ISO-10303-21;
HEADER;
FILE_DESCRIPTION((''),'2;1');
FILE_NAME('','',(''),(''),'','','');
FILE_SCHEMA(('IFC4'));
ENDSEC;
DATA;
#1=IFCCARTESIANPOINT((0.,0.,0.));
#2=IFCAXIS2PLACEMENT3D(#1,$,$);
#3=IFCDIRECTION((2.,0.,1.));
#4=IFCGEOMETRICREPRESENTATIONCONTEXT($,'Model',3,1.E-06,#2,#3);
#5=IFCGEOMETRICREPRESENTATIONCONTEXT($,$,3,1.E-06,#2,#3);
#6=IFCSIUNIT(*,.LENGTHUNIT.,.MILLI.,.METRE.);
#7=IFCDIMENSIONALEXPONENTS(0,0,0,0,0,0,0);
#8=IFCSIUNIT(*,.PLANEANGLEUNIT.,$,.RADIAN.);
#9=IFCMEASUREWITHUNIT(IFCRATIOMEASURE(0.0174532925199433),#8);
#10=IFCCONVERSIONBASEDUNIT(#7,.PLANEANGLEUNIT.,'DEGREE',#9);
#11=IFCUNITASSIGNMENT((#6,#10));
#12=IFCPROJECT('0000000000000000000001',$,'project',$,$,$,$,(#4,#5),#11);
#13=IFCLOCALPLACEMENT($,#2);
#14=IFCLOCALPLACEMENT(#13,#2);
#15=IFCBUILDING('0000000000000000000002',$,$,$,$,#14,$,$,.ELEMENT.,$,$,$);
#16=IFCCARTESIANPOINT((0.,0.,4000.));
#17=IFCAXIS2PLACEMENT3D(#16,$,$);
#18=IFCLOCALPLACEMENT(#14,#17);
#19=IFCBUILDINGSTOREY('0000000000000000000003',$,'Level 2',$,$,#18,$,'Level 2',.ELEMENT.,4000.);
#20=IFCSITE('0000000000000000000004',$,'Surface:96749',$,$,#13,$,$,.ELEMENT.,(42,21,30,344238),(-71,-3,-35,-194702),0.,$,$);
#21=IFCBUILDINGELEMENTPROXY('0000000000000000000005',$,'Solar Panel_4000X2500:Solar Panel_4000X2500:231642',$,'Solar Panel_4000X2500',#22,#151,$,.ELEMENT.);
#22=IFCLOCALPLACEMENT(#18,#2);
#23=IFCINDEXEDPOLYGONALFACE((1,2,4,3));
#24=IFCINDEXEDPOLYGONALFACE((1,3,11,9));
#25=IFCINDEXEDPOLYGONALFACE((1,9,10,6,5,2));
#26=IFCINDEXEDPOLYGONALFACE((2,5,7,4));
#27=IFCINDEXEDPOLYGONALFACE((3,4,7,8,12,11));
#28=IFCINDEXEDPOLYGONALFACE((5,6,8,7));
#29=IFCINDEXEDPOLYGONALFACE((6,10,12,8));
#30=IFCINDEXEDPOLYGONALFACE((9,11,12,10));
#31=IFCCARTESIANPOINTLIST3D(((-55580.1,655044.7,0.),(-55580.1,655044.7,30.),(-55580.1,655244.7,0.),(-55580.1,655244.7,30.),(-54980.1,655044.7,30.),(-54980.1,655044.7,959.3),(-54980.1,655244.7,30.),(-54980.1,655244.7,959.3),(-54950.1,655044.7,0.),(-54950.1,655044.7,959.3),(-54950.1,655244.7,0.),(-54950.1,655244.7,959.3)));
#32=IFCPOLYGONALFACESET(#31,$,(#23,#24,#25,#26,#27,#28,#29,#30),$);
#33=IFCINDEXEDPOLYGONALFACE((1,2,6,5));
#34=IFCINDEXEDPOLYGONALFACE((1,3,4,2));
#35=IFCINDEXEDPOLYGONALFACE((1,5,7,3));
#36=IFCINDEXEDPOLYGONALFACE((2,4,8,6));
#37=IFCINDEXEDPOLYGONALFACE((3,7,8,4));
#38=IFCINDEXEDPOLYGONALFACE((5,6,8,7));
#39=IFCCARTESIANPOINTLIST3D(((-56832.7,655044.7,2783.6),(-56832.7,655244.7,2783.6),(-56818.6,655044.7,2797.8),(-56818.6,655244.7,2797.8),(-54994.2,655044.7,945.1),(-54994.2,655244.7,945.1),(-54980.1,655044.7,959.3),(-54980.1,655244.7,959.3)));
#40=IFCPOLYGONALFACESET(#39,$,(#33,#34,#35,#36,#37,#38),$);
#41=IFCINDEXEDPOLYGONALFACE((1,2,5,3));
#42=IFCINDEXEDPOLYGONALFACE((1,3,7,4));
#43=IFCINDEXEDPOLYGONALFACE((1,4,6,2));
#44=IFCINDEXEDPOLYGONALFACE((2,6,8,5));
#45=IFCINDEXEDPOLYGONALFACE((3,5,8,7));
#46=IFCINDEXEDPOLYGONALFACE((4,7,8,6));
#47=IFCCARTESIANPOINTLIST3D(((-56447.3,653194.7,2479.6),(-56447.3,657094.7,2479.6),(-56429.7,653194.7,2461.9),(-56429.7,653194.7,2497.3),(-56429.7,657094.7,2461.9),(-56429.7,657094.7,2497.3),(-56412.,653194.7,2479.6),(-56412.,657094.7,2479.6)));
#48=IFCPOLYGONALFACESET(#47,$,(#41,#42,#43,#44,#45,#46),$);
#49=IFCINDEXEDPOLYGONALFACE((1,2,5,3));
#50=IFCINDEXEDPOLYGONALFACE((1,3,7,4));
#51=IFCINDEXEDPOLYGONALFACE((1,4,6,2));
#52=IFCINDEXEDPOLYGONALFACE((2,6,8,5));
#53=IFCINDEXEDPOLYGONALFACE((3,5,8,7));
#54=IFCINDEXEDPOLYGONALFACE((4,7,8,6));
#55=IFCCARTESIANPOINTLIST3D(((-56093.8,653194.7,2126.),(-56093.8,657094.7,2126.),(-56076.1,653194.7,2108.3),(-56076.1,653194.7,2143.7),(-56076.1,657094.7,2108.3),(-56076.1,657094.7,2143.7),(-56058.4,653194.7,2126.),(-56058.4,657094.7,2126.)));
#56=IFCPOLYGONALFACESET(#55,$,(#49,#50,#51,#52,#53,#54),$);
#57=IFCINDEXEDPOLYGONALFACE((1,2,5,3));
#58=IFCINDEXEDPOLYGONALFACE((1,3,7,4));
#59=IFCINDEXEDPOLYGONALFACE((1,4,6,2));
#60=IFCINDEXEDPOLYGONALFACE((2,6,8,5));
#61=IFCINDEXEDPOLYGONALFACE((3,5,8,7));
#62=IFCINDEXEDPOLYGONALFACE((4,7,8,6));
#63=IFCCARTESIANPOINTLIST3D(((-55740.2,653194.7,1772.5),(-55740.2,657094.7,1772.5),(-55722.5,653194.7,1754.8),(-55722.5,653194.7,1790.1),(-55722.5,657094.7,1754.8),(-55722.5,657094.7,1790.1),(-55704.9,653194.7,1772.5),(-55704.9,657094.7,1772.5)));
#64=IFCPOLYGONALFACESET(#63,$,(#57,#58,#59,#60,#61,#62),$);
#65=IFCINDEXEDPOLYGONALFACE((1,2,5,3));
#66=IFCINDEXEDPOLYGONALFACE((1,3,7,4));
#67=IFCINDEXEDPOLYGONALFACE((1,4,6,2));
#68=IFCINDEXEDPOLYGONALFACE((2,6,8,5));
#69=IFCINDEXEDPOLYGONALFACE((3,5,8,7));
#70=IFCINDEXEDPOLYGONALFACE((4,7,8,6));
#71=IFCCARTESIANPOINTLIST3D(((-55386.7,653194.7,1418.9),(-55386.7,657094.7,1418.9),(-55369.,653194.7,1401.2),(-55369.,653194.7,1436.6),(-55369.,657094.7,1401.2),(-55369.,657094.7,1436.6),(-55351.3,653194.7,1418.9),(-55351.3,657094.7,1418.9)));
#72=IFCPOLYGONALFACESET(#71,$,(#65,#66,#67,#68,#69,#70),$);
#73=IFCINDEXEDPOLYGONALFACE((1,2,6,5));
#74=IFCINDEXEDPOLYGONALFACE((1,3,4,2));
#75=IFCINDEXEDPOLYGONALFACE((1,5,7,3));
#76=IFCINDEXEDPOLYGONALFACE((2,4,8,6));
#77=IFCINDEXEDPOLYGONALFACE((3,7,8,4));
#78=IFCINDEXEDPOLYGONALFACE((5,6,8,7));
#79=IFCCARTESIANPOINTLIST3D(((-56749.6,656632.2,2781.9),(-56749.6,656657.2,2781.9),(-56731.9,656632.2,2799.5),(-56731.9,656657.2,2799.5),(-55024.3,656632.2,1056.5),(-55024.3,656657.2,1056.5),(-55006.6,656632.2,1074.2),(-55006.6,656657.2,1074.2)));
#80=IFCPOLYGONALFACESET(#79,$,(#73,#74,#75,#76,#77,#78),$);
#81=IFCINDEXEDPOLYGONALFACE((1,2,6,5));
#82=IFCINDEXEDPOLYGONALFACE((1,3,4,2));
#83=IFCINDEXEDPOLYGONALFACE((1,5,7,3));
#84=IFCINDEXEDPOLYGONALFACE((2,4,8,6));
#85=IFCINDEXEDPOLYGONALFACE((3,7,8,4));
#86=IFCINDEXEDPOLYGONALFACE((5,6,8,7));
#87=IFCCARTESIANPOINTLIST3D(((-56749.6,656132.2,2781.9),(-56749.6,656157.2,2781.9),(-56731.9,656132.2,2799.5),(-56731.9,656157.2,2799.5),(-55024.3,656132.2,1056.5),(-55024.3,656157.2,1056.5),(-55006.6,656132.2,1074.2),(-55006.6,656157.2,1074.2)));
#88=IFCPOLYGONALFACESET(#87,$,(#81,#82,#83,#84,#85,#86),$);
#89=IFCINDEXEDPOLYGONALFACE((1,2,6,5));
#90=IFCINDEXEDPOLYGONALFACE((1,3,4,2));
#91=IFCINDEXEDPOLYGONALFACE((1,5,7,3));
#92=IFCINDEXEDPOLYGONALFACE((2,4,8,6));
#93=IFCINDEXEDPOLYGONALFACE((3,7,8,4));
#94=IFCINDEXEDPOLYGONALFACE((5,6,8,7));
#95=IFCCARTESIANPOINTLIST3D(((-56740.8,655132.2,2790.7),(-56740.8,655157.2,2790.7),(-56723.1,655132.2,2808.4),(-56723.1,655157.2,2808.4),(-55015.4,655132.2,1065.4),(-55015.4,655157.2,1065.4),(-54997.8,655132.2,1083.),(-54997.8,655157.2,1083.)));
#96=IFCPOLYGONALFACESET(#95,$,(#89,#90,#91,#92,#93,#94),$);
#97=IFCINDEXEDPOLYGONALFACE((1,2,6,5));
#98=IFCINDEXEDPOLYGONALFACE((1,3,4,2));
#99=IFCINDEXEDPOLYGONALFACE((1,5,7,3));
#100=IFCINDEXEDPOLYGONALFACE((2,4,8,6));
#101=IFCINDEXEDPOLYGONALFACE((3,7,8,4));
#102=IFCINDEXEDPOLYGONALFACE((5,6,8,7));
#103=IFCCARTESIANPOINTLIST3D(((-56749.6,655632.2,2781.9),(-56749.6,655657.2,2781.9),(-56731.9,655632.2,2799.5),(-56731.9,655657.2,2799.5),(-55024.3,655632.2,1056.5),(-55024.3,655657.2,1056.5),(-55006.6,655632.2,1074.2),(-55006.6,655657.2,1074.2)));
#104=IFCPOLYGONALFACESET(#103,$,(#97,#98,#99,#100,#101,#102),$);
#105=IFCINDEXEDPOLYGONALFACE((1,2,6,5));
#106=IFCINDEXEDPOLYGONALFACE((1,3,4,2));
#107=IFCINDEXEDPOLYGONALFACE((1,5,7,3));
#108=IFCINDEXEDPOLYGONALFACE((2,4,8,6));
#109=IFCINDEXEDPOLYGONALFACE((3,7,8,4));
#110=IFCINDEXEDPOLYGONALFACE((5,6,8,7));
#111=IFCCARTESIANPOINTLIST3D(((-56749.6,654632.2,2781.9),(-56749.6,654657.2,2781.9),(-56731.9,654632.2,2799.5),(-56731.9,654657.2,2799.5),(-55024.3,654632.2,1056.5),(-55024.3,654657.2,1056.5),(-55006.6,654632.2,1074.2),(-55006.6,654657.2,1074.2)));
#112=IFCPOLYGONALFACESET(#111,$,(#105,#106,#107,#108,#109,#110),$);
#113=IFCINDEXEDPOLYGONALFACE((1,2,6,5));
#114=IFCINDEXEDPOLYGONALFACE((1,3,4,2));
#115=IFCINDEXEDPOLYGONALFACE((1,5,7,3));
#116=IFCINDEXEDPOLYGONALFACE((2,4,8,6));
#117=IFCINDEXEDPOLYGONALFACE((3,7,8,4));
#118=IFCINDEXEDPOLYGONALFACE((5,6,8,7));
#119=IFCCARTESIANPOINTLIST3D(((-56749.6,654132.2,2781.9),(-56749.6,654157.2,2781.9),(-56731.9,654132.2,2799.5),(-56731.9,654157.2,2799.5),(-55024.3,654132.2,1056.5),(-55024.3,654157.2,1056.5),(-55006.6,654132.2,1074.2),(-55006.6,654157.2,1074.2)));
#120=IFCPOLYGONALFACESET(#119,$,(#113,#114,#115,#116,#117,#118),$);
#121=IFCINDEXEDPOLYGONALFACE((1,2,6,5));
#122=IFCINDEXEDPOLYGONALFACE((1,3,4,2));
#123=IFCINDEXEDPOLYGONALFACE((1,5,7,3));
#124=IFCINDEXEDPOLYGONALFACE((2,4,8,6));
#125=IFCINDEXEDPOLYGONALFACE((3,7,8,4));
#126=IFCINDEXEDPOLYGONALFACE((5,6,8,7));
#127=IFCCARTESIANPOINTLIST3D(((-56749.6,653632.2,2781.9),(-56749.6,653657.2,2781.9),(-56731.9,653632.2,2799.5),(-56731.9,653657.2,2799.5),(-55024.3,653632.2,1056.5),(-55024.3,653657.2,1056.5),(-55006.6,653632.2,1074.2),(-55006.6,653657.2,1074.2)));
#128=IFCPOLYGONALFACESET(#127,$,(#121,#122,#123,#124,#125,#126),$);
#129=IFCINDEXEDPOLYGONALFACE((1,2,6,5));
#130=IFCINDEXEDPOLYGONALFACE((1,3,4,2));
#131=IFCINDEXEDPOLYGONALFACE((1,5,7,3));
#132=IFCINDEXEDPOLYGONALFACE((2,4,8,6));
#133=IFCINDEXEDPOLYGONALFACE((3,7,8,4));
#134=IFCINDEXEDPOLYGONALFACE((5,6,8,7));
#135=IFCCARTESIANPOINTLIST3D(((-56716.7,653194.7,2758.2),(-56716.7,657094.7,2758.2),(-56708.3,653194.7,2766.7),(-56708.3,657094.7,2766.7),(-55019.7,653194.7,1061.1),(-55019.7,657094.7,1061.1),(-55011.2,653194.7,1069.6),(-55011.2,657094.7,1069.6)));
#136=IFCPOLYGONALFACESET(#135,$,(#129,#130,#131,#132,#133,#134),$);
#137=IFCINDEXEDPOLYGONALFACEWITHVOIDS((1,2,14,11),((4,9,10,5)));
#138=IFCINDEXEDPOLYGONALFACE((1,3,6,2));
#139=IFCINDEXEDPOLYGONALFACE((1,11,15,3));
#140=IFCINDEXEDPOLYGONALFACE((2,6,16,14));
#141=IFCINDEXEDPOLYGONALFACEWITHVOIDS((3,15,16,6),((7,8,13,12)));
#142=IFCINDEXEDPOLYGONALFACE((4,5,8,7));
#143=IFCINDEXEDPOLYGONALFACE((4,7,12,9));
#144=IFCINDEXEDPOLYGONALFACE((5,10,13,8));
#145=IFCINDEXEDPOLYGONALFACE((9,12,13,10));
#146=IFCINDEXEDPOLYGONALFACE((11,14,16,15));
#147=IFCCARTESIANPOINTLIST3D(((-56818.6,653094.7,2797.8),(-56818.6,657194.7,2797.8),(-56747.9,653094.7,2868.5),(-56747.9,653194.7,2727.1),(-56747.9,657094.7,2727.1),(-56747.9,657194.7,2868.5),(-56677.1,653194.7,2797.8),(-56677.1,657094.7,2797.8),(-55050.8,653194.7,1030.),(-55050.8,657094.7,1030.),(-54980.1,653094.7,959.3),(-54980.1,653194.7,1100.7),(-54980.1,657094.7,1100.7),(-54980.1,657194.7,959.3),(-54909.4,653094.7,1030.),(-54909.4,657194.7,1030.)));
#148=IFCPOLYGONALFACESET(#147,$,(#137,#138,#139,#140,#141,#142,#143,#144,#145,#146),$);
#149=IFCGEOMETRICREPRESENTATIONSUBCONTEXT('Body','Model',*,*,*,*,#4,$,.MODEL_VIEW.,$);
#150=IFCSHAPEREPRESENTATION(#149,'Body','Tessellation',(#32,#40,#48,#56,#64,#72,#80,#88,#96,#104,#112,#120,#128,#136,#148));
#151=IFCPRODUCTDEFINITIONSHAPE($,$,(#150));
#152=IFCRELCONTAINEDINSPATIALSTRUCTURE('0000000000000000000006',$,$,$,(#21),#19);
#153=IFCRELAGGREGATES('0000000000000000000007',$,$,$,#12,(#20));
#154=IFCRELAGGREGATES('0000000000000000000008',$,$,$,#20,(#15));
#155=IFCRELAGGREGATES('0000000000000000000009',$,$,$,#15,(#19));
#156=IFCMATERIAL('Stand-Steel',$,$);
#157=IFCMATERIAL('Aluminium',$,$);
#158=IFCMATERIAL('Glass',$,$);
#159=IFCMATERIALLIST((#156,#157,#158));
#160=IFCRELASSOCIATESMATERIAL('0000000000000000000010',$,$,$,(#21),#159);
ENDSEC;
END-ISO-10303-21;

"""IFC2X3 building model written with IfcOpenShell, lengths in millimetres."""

from ifc_helpers import new_model, entity, si_unit, converted_unit, direction, frame, frame_2d, origin, origin_2d_with_axis, place, context, subcontext, project, spatial, polyline, rectangle, outline, extrude, source, transform, mapped, material, material_list, element, save


model = new_model("IFC2X3")

# Units and contexts
model_context = context("Model", 3, precision=1e-06, world=origin(), true_north=direction((2.0, 0.0, 1.0)))
context_of_model = context(None, 3, precision=1e-06, world=origin(), true_north=direction((2.0, 0.0, 1.0)))
body_context = subcontext(model_context, "Body", "Model", "MODEL_VIEW")
ifc_project = project(units=[si_unit("LENGTHUNIT", "METRE", prefix="MILLI"), converted_unit("PLANEANGLEUNIT", "DEGREE", entity("IfcRatioMeasure", 0.0174532925199433), si_unit("PLANEANGLEUNIT", "RADIAN"), dimensions=[0, 0, 0, 0, 0, 0, 0])], contexts=[model_context, context_of_model])

# Site, building, storey
site_placement = place(None, origin())
site = spatial("IfcSite", under=ifc_project, at=site_placement, Name="Surface:96749", CompositionType="ELEMENT", RefLatitude=(42, 21, 30, 344238), RefLongitude=(-71, -3, -35, -194702), RefElevation=0.0)
building_placement = place(site_placement, origin())
building = spatial("IfcBuilding", under=site, at=building_placement, CompositionType="ELEMENT")
storey_placement = place(building_placement, frame((0.0, 0.0, 4000.0)))
storey = spatial("IfcBuildingStorey", under=building, at=storey_placement, Name="Level 2", LongName="Level 2", CompositionType="ELEMENT", Elevation=4000.0)

# Building element proxy
ifc_material_1 = material(Name="Stand-Steel")
ifc_material_2 = material(Name="Aluminium")
ifc_material_3 = material(Name="Glass")
shared_shape = source(origin(), body_context, "Body", "SweptSolid", [
    extrude(outline(polyline([(-629.5, -220.0), (329.8, -220.0), (329.8, 410.0), (299.8, 410.0), (299.8, -190.0), (-629.5, -190.0), (-629.5, -220.0)])), frame((-190.0, -100.0, 299.8), z_axis=(0.0, 1.0, 0.0), x_axis=(0.0, 0.0, -1.0)), (0.0, 0.0, 1.0), 200.0),
    extrude(rectangle(XDim=20.0, YDim=200.0, at=frame_2d((0.0, 0.0), x_axis=(0.0, 1.0))), frame((-7.1, 0.0, 922.2), z_axis=(-0.707107, 0.0, 0.707107), x_axis=(0.0, 1.0, 0.0)), (0.0, 0.0, 1.0), 2600.0),
    extrude(rectangle(XDim=25.0, YDim=25.0, at=frame_2d((0.0, 0.0), x_axis=(1.0, 0.0))), frame((-1449.6, -1950.0, 2449.6), z_axis=(0.0, 1.0, 0.0), x_axis=(-0.707107, 0.0, -0.707107)), (0.0, 0.0, 1.0), 3900.0),
    extrude(rectangle(XDim=25.0, YDim=25.0, at=origin_2d_with_axis()), frame((-1096.0, -1950.0, 2096.0), z_axis=(0.0, 1.0, 0.0), x_axis=(-0.707107, 0.0, -0.707107)), (0.0, 0.0, 1.0), 3900.0),
    extrude(rectangle(XDim=25.0, YDim=25.0, at=origin_2d_with_axis()), frame((-742.5, -1950.0, 1742.5), z_axis=(0.0, 1.0, 0.0), x_axis=(-0.707107, 0.0, -0.707107)), (0.0, 0.0, 1.0), 3900.0),
    extrude(rectangle(XDim=25.0, YDim=25.0, at=frame_2d((0.0, 0.0), x_axis=(1.0, 0.0))), frame((-388.9, -1950.0, 1388.9), z_axis=(0.0, 1.0, 0.0), x_axis=(-0.707107, 0.0, -0.707107)), (0.0, 0.0, 1.0), 3900.0),
    extrude(rectangle(XDim=25.0, YDim=25.0, at=frame_2d((0.0, 0.0), x_axis=(0.0, 1.0))), frame((-35.4, 1500.0, 1035.4), z_axis=(-0.707107, 0.0, 0.707107), x_axis=(0.0, 1.0, 0.0)), (0.0, 0.0, 1.0), 2440.0),
    extrude(rectangle(XDim=25.0, YDim=25.0, at=frame_2d((0.0, 0.0), x_axis=(0.0, 1.0))), frame((-35.4, 1000.0, 1035.4), z_axis=(-0.707107, 0.0, 0.707107), x_axis=(0.0, 1.0, 0.0)), (0.0, 0.0, 1.0), 2440.0),
    extrude(rectangle(XDim=25.0, YDim=25.0, at=frame_2d((0.0, 0.0), x_axis=(0.0, 1.0))), frame((-26.5, 0.0, 1044.2), z_axis=(-0.707107, 0.0, 0.707107), x_axis=(0.0, -1.0, 0.0)), (0.0, 0.0, 1.0), 2440.0),
    extrude(rectangle(XDim=25.0, YDim=25.0, at=frame_2d((0.0, 0.0), x_axis=(0.0, 1.0))), frame((-35.4, 500.0, 1035.4), z_axis=(-0.707107, 0.0, 0.707107), x_axis=(0.0, 1.0, 0.0)), (0.0, 0.0, 1.0), 2440.0),
    extrude(rectangle(XDim=25.0, YDim=25.0, at=frame_2d((0.0, 0.0), x_axis=(0.0, 1.0))), frame((-35.4, -500.0, 1035.4), z_axis=(-0.707107, 0.0, 0.707107), x_axis=(0.0, 1.0, 0.0)), (0.0, 0.0, 1.0), 2440.0),
    extrude(rectangle(XDim=25.0, YDim=25.0, at=frame_2d((0.0, 0.0), x_axis=(0.0, 1.0))), frame((-35.4, -1000.0, 1035.4), z_axis=(-0.707107, 0.0, 0.707107), x_axis=(0.0, 1.0, 0.0)), (0.0, 0.0, 1.0), 2440.0),
    extrude(rectangle(XDim=25.0, YDim=25.0, at=frame_2d((0.0, 0.0), x_axis=(0.0, 1.0))), frame((-35.4, -1500.0, 1035.4), z_axis=(-0.707107, 0.0, 0.707107), x_axis=(0.0, 1.0, 0.0)), (0.0, 0.0, 1.0), 2440.0),
    extrude(rectangle(XDim=2400.0, YDim=12.0, at=frame_2d((0.0, 0.0), x_axis=(1.0, 0.0))), frame((-883.9, -1950.0, 1883.9), z_axis=(0.0, 1.0, 0.0), x_axis=(0.707107, 0.0, -0.707107)), (0.0, 0.0, 1.0), 3900.0),
    extrude(outline(polyline([(-2050.0, -1300.0), (2050.0, -1300.0), (2050.0, 1300.0), (-2050.0, 1300.0), (-2050.0, -1300.0)]), holes=[polyline([(1950.0, -1200.0), (-1950.0, -1200.0), (-1950.0, 1200.0), (1950.0, 1200.0), (1950.0, -1200.0)])]), frame((-919.2, 0.0, 1848.5), z_axis=(0.707107, 0.0, 0.707107), x_axis=(0.0, 1.0, 0.0)), (0.0, 0.0, 1.0), 100.0),
])
ifc_material_list_1 = material_list([ifc_material_1, ifc_material_2, ifc_material_3])
proxy_1_placement = place(storey_placement, frame((-54980.1, 655144.7, 30.0)))
element("IfcBuildingElementProxy", 1, at=proxy_1_placement, inside=storey, material=ifc_material_list_1, Name="Solar Panel_4000X2500:Solar Panel_4000X2500:231642", ObjectType="Solar Panel_4000X2500", CompositionType="ELEMENT", context=body_context, shape_type="MappedRepresentation", body=[
    mapped(shared_shape, transform((0.0, 0.0, 0.0), scale=1.0)),
])

save(model, "model.ifc")
